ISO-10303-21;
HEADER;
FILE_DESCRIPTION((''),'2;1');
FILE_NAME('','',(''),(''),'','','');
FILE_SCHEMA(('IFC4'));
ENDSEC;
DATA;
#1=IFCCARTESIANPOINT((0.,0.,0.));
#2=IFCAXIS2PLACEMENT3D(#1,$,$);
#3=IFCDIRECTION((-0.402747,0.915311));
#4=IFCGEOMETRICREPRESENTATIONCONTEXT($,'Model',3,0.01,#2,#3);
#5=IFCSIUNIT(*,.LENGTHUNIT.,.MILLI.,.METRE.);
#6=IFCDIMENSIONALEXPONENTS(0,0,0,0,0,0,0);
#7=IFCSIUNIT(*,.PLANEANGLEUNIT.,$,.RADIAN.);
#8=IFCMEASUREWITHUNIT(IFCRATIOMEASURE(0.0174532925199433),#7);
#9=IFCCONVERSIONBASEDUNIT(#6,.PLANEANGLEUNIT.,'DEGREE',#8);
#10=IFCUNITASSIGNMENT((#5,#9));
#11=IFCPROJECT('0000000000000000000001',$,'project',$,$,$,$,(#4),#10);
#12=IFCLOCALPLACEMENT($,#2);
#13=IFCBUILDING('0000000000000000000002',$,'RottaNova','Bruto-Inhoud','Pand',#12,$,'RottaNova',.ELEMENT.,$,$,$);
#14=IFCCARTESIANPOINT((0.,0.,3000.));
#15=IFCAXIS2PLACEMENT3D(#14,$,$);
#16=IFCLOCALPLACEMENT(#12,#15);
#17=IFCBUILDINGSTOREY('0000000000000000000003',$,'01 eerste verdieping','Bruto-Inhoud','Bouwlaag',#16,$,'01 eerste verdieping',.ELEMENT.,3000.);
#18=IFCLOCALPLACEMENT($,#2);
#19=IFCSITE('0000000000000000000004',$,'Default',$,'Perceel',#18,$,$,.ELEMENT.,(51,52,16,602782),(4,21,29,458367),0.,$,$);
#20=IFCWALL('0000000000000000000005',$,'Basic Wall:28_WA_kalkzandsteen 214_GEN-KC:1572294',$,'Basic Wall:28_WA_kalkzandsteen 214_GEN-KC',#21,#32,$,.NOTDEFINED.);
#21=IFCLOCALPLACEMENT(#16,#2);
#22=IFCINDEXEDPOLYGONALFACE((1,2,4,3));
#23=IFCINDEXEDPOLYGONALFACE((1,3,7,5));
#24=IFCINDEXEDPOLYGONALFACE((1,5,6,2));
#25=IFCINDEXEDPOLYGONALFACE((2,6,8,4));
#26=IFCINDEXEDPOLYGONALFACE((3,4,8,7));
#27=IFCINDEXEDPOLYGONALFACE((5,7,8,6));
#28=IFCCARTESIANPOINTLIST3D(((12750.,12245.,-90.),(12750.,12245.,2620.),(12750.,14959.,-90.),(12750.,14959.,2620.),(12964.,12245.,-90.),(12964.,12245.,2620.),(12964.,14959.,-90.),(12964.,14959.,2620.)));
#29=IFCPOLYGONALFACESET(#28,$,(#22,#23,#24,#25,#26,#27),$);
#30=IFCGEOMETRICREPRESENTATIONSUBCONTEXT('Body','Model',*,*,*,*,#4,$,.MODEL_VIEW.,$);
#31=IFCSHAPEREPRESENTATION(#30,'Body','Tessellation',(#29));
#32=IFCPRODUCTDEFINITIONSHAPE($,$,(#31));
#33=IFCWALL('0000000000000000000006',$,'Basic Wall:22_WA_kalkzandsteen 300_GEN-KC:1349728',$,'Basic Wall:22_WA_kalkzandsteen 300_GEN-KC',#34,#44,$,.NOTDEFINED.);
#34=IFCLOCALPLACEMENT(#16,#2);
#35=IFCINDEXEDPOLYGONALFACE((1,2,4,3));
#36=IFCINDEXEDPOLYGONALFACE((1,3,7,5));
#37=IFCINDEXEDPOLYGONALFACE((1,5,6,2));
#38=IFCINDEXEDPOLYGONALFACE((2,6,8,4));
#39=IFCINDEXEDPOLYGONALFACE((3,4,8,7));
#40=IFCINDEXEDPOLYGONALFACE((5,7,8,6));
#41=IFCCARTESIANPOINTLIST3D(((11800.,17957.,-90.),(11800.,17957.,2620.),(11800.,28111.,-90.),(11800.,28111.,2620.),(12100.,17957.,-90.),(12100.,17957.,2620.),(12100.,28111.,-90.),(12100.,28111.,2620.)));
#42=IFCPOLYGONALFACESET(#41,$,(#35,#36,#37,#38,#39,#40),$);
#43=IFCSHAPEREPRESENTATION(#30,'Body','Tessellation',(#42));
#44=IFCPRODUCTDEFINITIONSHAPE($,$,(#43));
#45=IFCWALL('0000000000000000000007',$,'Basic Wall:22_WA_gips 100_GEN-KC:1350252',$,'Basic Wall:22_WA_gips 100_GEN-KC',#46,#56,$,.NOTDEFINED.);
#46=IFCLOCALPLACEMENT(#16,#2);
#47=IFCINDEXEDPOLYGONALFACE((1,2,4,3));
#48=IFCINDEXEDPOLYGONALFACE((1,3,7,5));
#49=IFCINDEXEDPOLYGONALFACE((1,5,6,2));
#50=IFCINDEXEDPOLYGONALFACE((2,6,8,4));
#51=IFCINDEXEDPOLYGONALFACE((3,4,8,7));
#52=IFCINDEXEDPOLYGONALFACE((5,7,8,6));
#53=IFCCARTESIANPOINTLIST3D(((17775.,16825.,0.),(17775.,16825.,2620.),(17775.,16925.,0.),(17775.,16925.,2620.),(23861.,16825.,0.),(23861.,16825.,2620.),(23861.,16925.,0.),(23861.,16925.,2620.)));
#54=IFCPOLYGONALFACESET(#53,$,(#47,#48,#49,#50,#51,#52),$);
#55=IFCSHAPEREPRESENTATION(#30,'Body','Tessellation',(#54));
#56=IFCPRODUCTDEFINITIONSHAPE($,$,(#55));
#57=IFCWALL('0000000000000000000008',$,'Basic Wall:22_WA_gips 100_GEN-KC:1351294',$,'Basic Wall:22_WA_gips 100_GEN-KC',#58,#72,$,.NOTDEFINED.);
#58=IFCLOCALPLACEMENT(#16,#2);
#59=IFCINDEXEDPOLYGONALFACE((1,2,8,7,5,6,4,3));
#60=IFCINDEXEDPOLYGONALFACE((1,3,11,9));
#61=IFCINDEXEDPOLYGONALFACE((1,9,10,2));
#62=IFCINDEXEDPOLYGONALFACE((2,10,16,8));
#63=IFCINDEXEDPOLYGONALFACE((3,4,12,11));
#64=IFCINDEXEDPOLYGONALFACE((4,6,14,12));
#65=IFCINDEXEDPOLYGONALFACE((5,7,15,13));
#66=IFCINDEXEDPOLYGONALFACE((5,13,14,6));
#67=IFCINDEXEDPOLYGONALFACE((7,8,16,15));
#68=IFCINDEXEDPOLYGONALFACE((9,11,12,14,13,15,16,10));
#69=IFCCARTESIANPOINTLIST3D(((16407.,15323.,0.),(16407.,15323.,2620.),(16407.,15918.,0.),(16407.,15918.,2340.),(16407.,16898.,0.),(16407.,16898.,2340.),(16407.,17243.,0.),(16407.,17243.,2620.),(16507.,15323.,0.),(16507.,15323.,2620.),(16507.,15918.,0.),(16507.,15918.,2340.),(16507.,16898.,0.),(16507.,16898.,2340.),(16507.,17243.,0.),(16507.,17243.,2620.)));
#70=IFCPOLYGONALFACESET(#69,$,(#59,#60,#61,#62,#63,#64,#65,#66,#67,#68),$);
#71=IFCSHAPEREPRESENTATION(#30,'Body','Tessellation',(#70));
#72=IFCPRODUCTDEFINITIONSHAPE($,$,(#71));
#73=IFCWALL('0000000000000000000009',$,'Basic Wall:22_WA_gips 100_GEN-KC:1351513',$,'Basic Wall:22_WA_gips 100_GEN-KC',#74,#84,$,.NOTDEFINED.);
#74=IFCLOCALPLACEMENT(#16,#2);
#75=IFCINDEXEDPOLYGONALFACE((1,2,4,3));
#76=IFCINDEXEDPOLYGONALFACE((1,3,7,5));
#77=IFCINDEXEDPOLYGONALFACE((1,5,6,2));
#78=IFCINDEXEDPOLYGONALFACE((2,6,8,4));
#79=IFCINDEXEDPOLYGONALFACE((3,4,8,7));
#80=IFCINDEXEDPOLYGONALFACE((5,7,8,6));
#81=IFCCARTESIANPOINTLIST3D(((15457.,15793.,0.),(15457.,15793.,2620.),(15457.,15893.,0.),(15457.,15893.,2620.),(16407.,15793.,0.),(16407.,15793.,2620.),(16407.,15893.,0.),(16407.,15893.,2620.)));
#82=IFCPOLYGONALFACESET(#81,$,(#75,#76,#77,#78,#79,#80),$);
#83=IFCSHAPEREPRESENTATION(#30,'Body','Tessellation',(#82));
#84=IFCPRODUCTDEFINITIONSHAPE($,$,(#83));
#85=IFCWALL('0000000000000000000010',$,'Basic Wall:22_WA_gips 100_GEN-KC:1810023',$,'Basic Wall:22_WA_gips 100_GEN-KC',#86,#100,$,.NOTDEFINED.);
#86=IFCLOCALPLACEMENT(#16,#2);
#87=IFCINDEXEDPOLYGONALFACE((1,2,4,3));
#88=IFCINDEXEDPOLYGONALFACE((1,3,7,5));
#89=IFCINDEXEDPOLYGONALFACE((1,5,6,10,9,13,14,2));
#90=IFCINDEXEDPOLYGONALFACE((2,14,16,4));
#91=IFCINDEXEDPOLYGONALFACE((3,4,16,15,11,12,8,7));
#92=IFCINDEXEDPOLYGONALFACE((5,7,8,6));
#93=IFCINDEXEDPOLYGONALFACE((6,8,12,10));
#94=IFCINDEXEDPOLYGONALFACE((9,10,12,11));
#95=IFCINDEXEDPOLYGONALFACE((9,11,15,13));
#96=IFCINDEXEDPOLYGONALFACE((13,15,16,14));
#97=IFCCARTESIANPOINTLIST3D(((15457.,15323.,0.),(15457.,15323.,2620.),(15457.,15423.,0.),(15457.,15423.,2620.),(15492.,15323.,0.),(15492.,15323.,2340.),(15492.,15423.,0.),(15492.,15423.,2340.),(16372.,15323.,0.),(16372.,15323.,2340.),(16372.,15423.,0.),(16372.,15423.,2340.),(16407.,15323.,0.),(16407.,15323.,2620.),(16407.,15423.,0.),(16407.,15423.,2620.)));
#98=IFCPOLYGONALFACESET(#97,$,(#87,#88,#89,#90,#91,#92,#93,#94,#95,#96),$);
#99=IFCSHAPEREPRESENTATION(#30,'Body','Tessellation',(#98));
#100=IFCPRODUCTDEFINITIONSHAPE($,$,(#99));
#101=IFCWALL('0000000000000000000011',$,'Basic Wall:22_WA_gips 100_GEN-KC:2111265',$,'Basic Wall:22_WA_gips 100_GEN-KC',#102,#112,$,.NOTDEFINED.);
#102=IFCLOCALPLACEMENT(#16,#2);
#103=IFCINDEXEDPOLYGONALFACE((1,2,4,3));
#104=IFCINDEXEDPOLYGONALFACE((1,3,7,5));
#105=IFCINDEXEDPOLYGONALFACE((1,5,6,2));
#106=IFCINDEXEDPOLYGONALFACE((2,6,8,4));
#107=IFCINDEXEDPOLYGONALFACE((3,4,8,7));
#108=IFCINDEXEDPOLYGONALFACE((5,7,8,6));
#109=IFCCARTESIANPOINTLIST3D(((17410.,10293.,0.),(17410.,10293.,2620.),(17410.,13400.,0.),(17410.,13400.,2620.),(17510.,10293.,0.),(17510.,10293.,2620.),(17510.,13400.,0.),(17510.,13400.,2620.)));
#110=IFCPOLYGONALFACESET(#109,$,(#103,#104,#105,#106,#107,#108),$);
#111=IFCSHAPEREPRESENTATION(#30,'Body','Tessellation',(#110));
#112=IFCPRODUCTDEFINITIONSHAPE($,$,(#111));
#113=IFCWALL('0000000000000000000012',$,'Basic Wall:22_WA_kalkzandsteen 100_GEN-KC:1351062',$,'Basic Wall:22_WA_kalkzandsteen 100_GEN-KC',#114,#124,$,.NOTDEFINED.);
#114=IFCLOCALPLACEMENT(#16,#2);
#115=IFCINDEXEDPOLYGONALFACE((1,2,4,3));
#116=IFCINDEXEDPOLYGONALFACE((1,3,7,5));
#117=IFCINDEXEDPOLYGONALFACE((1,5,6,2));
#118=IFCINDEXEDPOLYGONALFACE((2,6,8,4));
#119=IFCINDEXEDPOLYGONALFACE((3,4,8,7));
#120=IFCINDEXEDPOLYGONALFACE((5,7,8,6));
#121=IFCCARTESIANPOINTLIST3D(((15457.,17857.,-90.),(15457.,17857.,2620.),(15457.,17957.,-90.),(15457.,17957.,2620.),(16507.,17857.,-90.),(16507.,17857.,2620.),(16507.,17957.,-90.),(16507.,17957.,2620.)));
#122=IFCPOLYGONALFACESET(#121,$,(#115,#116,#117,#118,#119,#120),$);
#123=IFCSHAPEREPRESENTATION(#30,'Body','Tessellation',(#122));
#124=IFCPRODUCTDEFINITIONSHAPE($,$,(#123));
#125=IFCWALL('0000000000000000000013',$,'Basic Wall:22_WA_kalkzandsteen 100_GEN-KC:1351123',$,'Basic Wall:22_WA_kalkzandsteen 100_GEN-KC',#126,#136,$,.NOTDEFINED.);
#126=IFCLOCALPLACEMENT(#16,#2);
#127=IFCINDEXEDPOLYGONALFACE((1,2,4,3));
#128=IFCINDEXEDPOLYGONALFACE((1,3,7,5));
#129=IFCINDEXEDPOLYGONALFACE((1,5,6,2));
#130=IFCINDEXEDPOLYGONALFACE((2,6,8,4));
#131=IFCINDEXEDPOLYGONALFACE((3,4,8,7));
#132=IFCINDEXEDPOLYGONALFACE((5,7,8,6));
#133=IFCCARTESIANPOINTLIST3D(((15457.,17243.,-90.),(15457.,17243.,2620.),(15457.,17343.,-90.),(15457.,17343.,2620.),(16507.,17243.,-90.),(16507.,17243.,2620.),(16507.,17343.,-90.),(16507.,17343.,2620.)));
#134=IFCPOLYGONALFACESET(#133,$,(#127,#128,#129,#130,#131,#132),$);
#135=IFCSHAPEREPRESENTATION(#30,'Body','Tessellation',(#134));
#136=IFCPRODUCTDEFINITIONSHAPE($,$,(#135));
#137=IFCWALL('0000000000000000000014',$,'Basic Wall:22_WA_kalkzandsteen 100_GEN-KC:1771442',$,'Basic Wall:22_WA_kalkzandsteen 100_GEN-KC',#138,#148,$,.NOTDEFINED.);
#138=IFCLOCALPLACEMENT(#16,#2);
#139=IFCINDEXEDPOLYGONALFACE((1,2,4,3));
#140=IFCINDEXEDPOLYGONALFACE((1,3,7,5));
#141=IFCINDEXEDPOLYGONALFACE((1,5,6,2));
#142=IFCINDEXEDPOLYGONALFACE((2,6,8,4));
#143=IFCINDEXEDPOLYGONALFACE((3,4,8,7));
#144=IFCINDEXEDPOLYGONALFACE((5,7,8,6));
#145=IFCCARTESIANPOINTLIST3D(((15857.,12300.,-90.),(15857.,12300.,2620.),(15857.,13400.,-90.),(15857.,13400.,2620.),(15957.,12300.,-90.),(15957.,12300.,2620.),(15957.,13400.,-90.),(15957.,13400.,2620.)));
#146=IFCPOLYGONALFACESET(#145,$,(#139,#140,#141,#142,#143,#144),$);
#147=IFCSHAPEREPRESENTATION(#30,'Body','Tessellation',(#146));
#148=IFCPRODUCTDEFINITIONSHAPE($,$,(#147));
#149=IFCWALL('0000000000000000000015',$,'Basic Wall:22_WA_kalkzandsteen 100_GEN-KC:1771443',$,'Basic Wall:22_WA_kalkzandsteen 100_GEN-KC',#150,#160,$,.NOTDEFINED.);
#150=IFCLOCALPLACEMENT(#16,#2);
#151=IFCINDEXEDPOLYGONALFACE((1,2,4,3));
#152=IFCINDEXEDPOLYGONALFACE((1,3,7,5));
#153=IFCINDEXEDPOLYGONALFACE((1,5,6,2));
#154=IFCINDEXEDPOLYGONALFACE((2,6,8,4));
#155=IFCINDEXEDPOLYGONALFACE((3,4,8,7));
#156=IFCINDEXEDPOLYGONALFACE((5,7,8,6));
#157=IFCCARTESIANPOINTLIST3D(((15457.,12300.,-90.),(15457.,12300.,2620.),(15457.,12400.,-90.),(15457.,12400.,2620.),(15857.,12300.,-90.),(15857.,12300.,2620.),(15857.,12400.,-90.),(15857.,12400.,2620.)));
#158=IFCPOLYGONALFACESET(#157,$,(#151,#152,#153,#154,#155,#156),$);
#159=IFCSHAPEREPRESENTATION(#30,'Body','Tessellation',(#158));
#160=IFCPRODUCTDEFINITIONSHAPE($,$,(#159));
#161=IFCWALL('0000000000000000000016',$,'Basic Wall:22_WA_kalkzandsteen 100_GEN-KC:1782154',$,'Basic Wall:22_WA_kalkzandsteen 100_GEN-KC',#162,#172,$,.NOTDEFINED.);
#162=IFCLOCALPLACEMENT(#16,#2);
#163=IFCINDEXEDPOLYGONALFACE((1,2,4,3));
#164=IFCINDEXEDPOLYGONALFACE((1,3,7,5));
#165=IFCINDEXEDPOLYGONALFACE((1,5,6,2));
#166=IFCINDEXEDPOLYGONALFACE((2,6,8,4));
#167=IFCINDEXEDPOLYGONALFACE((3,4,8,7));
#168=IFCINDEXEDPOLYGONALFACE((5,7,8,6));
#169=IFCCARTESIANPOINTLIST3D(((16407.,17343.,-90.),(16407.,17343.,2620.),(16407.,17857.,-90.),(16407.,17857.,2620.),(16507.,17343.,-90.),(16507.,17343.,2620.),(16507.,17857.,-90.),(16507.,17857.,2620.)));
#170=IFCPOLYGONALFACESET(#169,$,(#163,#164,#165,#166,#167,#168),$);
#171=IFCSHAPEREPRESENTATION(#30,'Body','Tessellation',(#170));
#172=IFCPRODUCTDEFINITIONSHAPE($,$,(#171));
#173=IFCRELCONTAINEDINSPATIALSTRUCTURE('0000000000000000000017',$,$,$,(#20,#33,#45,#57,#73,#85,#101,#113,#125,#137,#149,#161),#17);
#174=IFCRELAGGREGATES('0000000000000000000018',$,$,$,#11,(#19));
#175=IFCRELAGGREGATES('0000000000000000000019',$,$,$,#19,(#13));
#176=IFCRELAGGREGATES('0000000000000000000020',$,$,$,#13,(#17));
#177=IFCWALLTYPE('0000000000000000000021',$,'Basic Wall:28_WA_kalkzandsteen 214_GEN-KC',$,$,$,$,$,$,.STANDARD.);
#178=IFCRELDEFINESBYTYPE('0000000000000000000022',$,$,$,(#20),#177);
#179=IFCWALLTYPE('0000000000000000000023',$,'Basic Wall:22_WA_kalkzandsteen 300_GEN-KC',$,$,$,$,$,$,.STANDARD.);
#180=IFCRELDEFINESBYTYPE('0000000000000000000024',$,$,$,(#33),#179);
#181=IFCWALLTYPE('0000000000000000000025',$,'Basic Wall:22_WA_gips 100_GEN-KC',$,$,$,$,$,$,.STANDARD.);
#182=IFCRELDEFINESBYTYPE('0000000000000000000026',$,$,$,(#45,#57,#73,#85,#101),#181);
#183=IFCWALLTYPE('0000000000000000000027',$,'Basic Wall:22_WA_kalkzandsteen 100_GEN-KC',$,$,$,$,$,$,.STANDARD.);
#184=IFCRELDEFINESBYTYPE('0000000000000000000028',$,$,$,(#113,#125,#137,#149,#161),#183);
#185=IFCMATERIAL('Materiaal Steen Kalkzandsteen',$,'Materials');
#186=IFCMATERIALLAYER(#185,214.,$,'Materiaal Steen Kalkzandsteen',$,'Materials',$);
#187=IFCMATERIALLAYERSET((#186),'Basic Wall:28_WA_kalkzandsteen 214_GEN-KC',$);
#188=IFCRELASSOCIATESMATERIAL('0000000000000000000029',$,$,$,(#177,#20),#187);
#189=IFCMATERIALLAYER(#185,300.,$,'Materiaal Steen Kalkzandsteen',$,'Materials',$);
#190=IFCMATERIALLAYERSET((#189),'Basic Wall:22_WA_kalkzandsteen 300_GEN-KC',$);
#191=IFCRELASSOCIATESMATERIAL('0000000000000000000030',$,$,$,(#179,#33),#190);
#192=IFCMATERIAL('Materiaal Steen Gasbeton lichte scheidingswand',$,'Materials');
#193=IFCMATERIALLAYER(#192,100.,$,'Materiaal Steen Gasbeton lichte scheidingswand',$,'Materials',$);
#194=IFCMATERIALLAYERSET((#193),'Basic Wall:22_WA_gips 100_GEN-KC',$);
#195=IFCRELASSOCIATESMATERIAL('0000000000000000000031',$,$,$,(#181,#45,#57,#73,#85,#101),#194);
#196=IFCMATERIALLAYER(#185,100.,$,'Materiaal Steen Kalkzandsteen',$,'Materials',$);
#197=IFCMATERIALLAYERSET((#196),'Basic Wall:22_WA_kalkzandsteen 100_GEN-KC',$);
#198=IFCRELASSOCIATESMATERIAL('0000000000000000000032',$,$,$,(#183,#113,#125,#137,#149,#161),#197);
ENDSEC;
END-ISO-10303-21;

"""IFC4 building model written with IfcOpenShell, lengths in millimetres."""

from ifc_helpers import new_model, entity, si_unit, converted_unit, direction, frame, frame_2d, origin, place, context, subcontext, project, spatial, rectangle, extrude, material, layer, layer_set, type_object, element, save


model = new_model("IFC4")

# Units and contexts
model_context = context("Model", 3, precision=0.01, world=origin(), true_north=direction((-0.402747, 0.915311)))
body_context = subcontext(model_context, "Body", "Model", "MODEL_VIEW")
ifc_project = project(units=[si_unit("LENGTHUNIT", "METRE", prefix="MILLI"), converted_unit("PLANEANGLEUNIT", "DEGREE", entity("IfcRatioMeasure", 0.0174532925199433), si_unit("PLANEANGLEUNIT", "RADIAN"), dimensions=[0, 0, 0, 0, 0, 0, 0])], contexts=[model_context])

# Site, building, storey
site_placement = place(None, origin())
site = spatial("IfcSite", under=ifc_project, at=site_placement, Name="Default", ObjectType="Perceel", CompositionType="ELEMENT", RefLatitude=(51, 52, 16, 602782), RefLongitude=(4, 21, 29, 458367), RefElevation=0.0)
building_placement = place(None, origin())
building = spatial("IfcBuilding", under=site, at=building_placement, Name="RottaNova", Description="Bruto-Inhoud", ObjectType="Pand", LongName="RottaNova", CompositionType="ELEMENT")
storey_placement = place(building_placement, frame((0.0, 0.0, 3000.0)))
storey = spatial("IfcBuildingStorey", under=building, at=storey_placement, Name="01 eerste verdieping", Description="Bruto-Inhoud", ObjectType="Bouwlaag", LongName="01 eerste verdieping", CompositionType="ELEMENT", Elevation=3000.0)

# Walls
ifc_material_1 = material(Name="Materiaal Steen Kalkzandsteen", Category="Materials")
ifc_layer_1 = layer(ifc_material_1, 214.0, Name="Materiaal Steen Kalkzandsteen", Category="Materials")
ifc_layer_set_1 = layer_set([ifc_layer_1], Name="Basic Wall:28_WA_kalkzandsteen 214_GEN-KC")
wall_type_1 = type_object("IfcWallType", Name="Basic Wall:28_WA_kalkzandsteen 214_GEN-KC", PredefinedType="STANDARD", material=ifc_layer_set_1)
wall_1_placement = place(storey_placement, frame((12857.0, 12245.0, -90.0), z_axis=(0.0, 0.0, 1.0), x_axis=(0.0, 1.0, 0.0)))
element("IfcWall", 1, at=wall_1_placement, inside=storey, type_object=wall_type_1, material=ifc_layer_set_1, Name="Basic Wall:28_WA_kalkzandsteen 214_GEN-KC:1572294", ObjectType="Basic Wall:28_WA_kalkzandsteen 214_GEN-KC", PredefinedType="NOTDEFINED", context=body_context, shape_type="SweptSolid", body=[
    extrude(rectangle(XDim=2714.0, YDim=214.0, at=frame_2d((1357.0, 0.0), x_axis=(-1.0, 0.0))), origin(), (0.0, 0.0, 1.0), 2710.0),
])
ifc_layer_2 = layer(ifc_material_1, 300.0, Name="Materiaal Steen Kalkzandsteen", Category="Materials")
ifc_layer_set_2 = layer_set([ifc_layer_2], Name="Basic Wall:22_WA_kalkzandsteen 300_GEN-KC")
wall_type_2 = type_object("IfcWallType", Name="Basic Wall:22_WA_kalkzandsteen 300_GEN-KC", PredefinedType="STANDARD", material=ifc_layer_set_2)
wall_2_placement = place(storey_placement, frame((11950.0, 17957.0, -90.0), z_axis=(0.0, 0.0, 1.0), x_axis=(0.0, 1.0, 0.0)))
element("IfcWall", 2, at=wall_2_placement, inside=storey, type_object=wall_type_2, material=ifc_layer_set_2, Name="Basic Wall:22_WA_kalkzandsteen 300_GEN-KC:1349728", ObjectType="Basic Wall:22_WA_kalkzandsteen 300_GEN-KC", PredefinedType="NOTDEFINED", context=body_context, shape_type="SweptSolid", body=[
    extrude(rectangle(XDim=10154.0, YDim=300.0, at=frame_2d((5077.0, 0.0), x_axis=(-1.0, 0.0))), origin(), (0.0, 0.0, 1.0), 2710.0),
])
ifc_material_2 = material(Name="Materiaal Steen Gasbeton lichte scheidingswand", Category="Materials")
ifc_layer_3 = layer(ifc_material_2, 100.0, Name="Materiaal Steen Gasbeton lichte scheidingswand", Category="Materials")
ifc_layer_set_3 = layer_set([ifc_layer_3], Name="Basic Wall:22_WA_gips 100_GEN-KC")
wall_type_3 = type_object("IfcWallType", Name="Basic Wall:22_WA_gips 100_GEN-KC", PredefinedType="STANDARD", material=ifc_layer_set_3)
wall_3_placement = place(storey_placement, frame((23861.0, 16875.0, 0.0), z_axis=(0.0, 0.0, 1.0), x_axis=(-1.0, 0.0, 0.0)))
element("IfcWall", 3, at=wall_3_placement, inside=storey, type_object=wall_type_3, material=ifc_layer_set_3, Name="Basic Wall:22_WA_gips 100_GEN-KC:1350252", ObjectType="Basic Wall:22_WA_gips 100_GEN-KC", PredefinedType="NOTDEFINED", context=body_context, shape_type="SweptSolid", body=[
    extrude(rectangle(XDim=6086.0, YDim=100.0, at=frame_2d((3043.0, 0.0), x_axis=(-1.0, 0.0))), origin(), (0.0, 0.0, 1.0), 2620.0),
])

# Wall, opening
wall_4_placement = place(storey_placement, frame((16457.0, 17243.0, 0.0), z_axis=(0.0, 0.0, 1.0), x_axis=(0.0, -1.0, 0.0)))
wall_4 = element("IfcWall", 4, at=wall_4_placement, inside=storey, type_object=wall_type_3, material=ifc_layer_set_3, Name="Basic Wall:22_WA_gips 100_GEN-KC:1351294", ObjectType="Basic Wall:22_WA_gips 100_GEN-KC", PredefinedType="NOTDEFINED", context=body_context, shape_type="SweptSolid", body=[
    extrude(rectangle(XDim=1920.0, YDim=100.0, at=frame_2d((960.0, 0.0), x_axis=(1.0, 0.0))), origin(), (0.0, 0.0, 1.0), 2620.0),
])
opening_1_placement = place(wall_4_placement, frame((345.0, -50.0, -90.0)))
element("IfcOpeningElement", 5, at=opening_1_placement, cuts=wall_4, PredefinedType="OPENING", context=body_context, shape_type="SweptSolid", body=[
    extrude(rectangle(XDim=2430.0, YDim=980.0, at=frame_2d((1215.0, 490.0), x_axis=(1.0, 0.0))), frame((0.0, 0.0, 0.0), z_axis=(0.0, 1.0, 0.0), x_axis=(0.0, 0.0, 1.0)), (0.0, 0.0, 1.0), 100.0),
])

# Wall
wall_5_placement = place(storey_placement, frame((16407.0, 15843.0, 0.0), z_axis=(0.0, 0.0, 1.0), x_axis=(-1.0, 0.0, 0.0)))
element("IfcWall", 6, at=wall_5_placement, inside=storey, type_object=wall_type_3, material=ifc_layer_set_3, Name="Basic Wall:22_WA_gips 100_GEN-KC:1351513", ObjectType="Basic Wall:22_WA_gips 100_GEN-KC", PredefinedType="NOTDEFINED", context=body_context, shape_type="SweptSolid", body=[
    extrude(rectangle(XDim=950.0, YDim=100.0, at=frame_2d((475.0, 0.0), x_axis=(-1.0, 0.0))), origin(), (0.0, 0.0, 1.0), 2620.0),
])

# Wall, opening
wall_6_placement = place(storey_placement, frame((16407.0, 15373.0, 0.0), z_axis=(0.0, 0.0, 1.0), x_axis=(-1.0, 0.0, 0.0)))
wall_6 = element("IfcWall", 7, at=wall_6_placement, inside=storey, type_object=wall_type_3, material=ifc_layer_set_3, Name="Basic Wall:22_WA_gips 100_GEN-KC:1810023", ObjectType="Basic Wall:22_WA_gips 100_GEN-KC", PredefinedType="NOTDEFINED", context=body_context, shape_type="SweptSolid", body=[
    extrude(rectangle(XDim=950.0, YDim=100.0, at=frame_2d((475.0, 0.0), x_axis=(1.0, 0.0))), origin(), (0.0, 0.0, 1.0), 2620.0),
])
opening_2_placement = place(wall_6_placement, frame((35.0, -50.0, -70.0)))
element("IfcOpeningElement", 8, at=opening_2_placement, cuts=wall_6, PredefinedType="OPENING", context=body_context, shape_type="SweptSolid", body=[
    extrude(rectangle(XDim=2410.0, YDim=880.0, at=frame_2d((1205.0, 440.0), x_axis=(1.0, 0.0))), frame((0.0, 0.0, 0.0), z_axis=(0.0, 1.0, 0.0), x_axis=(0.0, 0.0, 1.0)), (0.0, 0.0, 1.0), 100.0),
])

# Walls
wall_7_placement = place(storey_placement, frame((17460.0, 13400.0, 0.0), z_axis=(0.0, 0.0, 1.0), x_axis=(0.0, -1.0, 0.0)))
element("IfcWall", 9, at=wall_7_placement, inside=storey, type_object=wall_type_3, material=ifc_layer_set_3, Name="Basic Wall:22_WA_gips 100_GEN-KC:2111265", ObjectType="Basic Wall:22_WA_gips 100_GEN-KC", PredefinedType="NOTDEFINED", context=body_context, shape_type="SweptSolid", body=[
    extrude(rectangle(XDim=3107.0, YDim=100.0, at=frame_2d((1553.5, 0.0), x_axis=(-1.0, 0.0))), origin(), (0.0, 0.0, 1.0), 2620.0),
])
ifc_layer_4 = layer(ifc_material_1, 100.0, Name="Materiaal Steen Kalkzandsteen", Category="Materials")
ifc_layer_set_4 = layer_set([ifc_layer_4], Name="Basic Wall:22_WA_kalkzandsteen 100_GEN-KC")
wall_type_4 = type_object("IfcWallType", Name="Basic Wall:22_WA_kalkzandsteen 100_GEN-KC", PredefinedType="STANDARD", material=ifc_layer_set_4)
for number, where, z_axis, x_axis, name in (
    (10, (16507.0, 17907.0, -90.0), (0.0, 0.0, 1.0), (-1.0, 0.0, 0.0), "Basic Wall:22_WA_kalkzandsteen 100_GEN-KC:1351062"),
    (11, (16507.0, 17293.0, -90.0), (0.0, 0.0, 1.0), (-1.0, 0.0, 0.0), "Basic Wall:22_WA_kalkzandsteen 100_GEN-KC:1351123"),
):
    element("IfcWall", number, at=place(storey_placement, frame(where, z_axis=z_axis, x_axis=x_axis)), inside=storey, type_object=wall_type_4, material=ifc_layer_set_4, Name=name, ObjectType="Basic Wall:22_WA_kalkzandsteen 100_GEN-KC", PredefinedType="NOTDEFINED", context=body_context, shape_type="SweptSolid", body=[
        extrude(rectangle(XDim=1050.0, YDim=100.0, at=frame_2d((525.0, 0.0), x_axis=(-1.0, 0.0))), origin(), (0.0, 0.0, 1.0), 2710.0),
    ])
wall_8_placement = place(storey_placement, frame((15907.0, 13400.0, -90.0), z_axis=(0.0, 0.0, 1.0), x_axis=(0.0, -1.0, 0.0)))
element("IfcWall", 12, at=wall_8_placement, inside=storey, type_object=wall_type_4, material=ifc_layer_set_4, Name="Basic Wall:22_WA_kalkzandsteen 100_GEN-KC:1771442", ObjectType="Basic Wall:22_WA_kalkzandsteen 100_GEN-KC", PredefinedType="NOTDEFINED", context=body_context, shape_type="SweptSolid", body=[
    extrude(rectangle(XDim=1100.0, YDim=100.0, at=frame_2d((550.0, 0.0), x_axis=(-1.0, 0.0))), origin(), (0.0, 0.0, 1.0), 2710.0),
])
wall_9_placement = place(storey_placement, frame((15857.0, 12350.0, -90.0), z_axis=(0.0, 0.0, 1.0), x_axis=(-1.0, 0.0, 0.0)))
element("IfcWall", 13, at=wall_9_placement, inside=storey, type_object=wall_type_4, material=ifc_layer_set_4, Name="Basic Wall:22_WA_kalkzandsteen 100_GEN-KC:1771443", ObjectType="Basic Wall:22_WA_kalkzandsteen 100_GEN-KC", PredefinedType="NOTDEFINED", context=body_context, shape_type="SweptSolid", body=[
    extrude(rectangle(XDim=400.0, YDim=100.0, at=frame_2d((200.0, 0.0), x_axis=(-1.0, 0.0))), origin(), (0.0, 0.0, 1.0), 2710.0),
])
wall_10_placement = place(storey_placement, frame((16457.0, 17343.0, -90.0), z_axis=(0.0, 0.0, 1.0), x_axis=(0.0, 1.0, 0.0)))
element("IfcWall", 14, at=wall_10_placement, inside=storey, type_object=wall_type_4, material=ifc_layer_set_4, Name="Basic Wall:22_WA_kalkzandsteen 100_GEN-KC:1782154", ObjectType="Basic Wall:22_WA_kalkzandsteen 100_GEN-KC", PredefinedType="NOTDEFINED", context=body_context, shape_type="SweptSolid", body=[
    extrude(rectangle(XDim=514.0, YDim=100.0, at=frame_2d((257.0, 0.0), x_axis=(-1.0, 0.0))), origin(), (0.0, 0.0, 1.0), 2710.0),
])

save(model, "model.ifc")
